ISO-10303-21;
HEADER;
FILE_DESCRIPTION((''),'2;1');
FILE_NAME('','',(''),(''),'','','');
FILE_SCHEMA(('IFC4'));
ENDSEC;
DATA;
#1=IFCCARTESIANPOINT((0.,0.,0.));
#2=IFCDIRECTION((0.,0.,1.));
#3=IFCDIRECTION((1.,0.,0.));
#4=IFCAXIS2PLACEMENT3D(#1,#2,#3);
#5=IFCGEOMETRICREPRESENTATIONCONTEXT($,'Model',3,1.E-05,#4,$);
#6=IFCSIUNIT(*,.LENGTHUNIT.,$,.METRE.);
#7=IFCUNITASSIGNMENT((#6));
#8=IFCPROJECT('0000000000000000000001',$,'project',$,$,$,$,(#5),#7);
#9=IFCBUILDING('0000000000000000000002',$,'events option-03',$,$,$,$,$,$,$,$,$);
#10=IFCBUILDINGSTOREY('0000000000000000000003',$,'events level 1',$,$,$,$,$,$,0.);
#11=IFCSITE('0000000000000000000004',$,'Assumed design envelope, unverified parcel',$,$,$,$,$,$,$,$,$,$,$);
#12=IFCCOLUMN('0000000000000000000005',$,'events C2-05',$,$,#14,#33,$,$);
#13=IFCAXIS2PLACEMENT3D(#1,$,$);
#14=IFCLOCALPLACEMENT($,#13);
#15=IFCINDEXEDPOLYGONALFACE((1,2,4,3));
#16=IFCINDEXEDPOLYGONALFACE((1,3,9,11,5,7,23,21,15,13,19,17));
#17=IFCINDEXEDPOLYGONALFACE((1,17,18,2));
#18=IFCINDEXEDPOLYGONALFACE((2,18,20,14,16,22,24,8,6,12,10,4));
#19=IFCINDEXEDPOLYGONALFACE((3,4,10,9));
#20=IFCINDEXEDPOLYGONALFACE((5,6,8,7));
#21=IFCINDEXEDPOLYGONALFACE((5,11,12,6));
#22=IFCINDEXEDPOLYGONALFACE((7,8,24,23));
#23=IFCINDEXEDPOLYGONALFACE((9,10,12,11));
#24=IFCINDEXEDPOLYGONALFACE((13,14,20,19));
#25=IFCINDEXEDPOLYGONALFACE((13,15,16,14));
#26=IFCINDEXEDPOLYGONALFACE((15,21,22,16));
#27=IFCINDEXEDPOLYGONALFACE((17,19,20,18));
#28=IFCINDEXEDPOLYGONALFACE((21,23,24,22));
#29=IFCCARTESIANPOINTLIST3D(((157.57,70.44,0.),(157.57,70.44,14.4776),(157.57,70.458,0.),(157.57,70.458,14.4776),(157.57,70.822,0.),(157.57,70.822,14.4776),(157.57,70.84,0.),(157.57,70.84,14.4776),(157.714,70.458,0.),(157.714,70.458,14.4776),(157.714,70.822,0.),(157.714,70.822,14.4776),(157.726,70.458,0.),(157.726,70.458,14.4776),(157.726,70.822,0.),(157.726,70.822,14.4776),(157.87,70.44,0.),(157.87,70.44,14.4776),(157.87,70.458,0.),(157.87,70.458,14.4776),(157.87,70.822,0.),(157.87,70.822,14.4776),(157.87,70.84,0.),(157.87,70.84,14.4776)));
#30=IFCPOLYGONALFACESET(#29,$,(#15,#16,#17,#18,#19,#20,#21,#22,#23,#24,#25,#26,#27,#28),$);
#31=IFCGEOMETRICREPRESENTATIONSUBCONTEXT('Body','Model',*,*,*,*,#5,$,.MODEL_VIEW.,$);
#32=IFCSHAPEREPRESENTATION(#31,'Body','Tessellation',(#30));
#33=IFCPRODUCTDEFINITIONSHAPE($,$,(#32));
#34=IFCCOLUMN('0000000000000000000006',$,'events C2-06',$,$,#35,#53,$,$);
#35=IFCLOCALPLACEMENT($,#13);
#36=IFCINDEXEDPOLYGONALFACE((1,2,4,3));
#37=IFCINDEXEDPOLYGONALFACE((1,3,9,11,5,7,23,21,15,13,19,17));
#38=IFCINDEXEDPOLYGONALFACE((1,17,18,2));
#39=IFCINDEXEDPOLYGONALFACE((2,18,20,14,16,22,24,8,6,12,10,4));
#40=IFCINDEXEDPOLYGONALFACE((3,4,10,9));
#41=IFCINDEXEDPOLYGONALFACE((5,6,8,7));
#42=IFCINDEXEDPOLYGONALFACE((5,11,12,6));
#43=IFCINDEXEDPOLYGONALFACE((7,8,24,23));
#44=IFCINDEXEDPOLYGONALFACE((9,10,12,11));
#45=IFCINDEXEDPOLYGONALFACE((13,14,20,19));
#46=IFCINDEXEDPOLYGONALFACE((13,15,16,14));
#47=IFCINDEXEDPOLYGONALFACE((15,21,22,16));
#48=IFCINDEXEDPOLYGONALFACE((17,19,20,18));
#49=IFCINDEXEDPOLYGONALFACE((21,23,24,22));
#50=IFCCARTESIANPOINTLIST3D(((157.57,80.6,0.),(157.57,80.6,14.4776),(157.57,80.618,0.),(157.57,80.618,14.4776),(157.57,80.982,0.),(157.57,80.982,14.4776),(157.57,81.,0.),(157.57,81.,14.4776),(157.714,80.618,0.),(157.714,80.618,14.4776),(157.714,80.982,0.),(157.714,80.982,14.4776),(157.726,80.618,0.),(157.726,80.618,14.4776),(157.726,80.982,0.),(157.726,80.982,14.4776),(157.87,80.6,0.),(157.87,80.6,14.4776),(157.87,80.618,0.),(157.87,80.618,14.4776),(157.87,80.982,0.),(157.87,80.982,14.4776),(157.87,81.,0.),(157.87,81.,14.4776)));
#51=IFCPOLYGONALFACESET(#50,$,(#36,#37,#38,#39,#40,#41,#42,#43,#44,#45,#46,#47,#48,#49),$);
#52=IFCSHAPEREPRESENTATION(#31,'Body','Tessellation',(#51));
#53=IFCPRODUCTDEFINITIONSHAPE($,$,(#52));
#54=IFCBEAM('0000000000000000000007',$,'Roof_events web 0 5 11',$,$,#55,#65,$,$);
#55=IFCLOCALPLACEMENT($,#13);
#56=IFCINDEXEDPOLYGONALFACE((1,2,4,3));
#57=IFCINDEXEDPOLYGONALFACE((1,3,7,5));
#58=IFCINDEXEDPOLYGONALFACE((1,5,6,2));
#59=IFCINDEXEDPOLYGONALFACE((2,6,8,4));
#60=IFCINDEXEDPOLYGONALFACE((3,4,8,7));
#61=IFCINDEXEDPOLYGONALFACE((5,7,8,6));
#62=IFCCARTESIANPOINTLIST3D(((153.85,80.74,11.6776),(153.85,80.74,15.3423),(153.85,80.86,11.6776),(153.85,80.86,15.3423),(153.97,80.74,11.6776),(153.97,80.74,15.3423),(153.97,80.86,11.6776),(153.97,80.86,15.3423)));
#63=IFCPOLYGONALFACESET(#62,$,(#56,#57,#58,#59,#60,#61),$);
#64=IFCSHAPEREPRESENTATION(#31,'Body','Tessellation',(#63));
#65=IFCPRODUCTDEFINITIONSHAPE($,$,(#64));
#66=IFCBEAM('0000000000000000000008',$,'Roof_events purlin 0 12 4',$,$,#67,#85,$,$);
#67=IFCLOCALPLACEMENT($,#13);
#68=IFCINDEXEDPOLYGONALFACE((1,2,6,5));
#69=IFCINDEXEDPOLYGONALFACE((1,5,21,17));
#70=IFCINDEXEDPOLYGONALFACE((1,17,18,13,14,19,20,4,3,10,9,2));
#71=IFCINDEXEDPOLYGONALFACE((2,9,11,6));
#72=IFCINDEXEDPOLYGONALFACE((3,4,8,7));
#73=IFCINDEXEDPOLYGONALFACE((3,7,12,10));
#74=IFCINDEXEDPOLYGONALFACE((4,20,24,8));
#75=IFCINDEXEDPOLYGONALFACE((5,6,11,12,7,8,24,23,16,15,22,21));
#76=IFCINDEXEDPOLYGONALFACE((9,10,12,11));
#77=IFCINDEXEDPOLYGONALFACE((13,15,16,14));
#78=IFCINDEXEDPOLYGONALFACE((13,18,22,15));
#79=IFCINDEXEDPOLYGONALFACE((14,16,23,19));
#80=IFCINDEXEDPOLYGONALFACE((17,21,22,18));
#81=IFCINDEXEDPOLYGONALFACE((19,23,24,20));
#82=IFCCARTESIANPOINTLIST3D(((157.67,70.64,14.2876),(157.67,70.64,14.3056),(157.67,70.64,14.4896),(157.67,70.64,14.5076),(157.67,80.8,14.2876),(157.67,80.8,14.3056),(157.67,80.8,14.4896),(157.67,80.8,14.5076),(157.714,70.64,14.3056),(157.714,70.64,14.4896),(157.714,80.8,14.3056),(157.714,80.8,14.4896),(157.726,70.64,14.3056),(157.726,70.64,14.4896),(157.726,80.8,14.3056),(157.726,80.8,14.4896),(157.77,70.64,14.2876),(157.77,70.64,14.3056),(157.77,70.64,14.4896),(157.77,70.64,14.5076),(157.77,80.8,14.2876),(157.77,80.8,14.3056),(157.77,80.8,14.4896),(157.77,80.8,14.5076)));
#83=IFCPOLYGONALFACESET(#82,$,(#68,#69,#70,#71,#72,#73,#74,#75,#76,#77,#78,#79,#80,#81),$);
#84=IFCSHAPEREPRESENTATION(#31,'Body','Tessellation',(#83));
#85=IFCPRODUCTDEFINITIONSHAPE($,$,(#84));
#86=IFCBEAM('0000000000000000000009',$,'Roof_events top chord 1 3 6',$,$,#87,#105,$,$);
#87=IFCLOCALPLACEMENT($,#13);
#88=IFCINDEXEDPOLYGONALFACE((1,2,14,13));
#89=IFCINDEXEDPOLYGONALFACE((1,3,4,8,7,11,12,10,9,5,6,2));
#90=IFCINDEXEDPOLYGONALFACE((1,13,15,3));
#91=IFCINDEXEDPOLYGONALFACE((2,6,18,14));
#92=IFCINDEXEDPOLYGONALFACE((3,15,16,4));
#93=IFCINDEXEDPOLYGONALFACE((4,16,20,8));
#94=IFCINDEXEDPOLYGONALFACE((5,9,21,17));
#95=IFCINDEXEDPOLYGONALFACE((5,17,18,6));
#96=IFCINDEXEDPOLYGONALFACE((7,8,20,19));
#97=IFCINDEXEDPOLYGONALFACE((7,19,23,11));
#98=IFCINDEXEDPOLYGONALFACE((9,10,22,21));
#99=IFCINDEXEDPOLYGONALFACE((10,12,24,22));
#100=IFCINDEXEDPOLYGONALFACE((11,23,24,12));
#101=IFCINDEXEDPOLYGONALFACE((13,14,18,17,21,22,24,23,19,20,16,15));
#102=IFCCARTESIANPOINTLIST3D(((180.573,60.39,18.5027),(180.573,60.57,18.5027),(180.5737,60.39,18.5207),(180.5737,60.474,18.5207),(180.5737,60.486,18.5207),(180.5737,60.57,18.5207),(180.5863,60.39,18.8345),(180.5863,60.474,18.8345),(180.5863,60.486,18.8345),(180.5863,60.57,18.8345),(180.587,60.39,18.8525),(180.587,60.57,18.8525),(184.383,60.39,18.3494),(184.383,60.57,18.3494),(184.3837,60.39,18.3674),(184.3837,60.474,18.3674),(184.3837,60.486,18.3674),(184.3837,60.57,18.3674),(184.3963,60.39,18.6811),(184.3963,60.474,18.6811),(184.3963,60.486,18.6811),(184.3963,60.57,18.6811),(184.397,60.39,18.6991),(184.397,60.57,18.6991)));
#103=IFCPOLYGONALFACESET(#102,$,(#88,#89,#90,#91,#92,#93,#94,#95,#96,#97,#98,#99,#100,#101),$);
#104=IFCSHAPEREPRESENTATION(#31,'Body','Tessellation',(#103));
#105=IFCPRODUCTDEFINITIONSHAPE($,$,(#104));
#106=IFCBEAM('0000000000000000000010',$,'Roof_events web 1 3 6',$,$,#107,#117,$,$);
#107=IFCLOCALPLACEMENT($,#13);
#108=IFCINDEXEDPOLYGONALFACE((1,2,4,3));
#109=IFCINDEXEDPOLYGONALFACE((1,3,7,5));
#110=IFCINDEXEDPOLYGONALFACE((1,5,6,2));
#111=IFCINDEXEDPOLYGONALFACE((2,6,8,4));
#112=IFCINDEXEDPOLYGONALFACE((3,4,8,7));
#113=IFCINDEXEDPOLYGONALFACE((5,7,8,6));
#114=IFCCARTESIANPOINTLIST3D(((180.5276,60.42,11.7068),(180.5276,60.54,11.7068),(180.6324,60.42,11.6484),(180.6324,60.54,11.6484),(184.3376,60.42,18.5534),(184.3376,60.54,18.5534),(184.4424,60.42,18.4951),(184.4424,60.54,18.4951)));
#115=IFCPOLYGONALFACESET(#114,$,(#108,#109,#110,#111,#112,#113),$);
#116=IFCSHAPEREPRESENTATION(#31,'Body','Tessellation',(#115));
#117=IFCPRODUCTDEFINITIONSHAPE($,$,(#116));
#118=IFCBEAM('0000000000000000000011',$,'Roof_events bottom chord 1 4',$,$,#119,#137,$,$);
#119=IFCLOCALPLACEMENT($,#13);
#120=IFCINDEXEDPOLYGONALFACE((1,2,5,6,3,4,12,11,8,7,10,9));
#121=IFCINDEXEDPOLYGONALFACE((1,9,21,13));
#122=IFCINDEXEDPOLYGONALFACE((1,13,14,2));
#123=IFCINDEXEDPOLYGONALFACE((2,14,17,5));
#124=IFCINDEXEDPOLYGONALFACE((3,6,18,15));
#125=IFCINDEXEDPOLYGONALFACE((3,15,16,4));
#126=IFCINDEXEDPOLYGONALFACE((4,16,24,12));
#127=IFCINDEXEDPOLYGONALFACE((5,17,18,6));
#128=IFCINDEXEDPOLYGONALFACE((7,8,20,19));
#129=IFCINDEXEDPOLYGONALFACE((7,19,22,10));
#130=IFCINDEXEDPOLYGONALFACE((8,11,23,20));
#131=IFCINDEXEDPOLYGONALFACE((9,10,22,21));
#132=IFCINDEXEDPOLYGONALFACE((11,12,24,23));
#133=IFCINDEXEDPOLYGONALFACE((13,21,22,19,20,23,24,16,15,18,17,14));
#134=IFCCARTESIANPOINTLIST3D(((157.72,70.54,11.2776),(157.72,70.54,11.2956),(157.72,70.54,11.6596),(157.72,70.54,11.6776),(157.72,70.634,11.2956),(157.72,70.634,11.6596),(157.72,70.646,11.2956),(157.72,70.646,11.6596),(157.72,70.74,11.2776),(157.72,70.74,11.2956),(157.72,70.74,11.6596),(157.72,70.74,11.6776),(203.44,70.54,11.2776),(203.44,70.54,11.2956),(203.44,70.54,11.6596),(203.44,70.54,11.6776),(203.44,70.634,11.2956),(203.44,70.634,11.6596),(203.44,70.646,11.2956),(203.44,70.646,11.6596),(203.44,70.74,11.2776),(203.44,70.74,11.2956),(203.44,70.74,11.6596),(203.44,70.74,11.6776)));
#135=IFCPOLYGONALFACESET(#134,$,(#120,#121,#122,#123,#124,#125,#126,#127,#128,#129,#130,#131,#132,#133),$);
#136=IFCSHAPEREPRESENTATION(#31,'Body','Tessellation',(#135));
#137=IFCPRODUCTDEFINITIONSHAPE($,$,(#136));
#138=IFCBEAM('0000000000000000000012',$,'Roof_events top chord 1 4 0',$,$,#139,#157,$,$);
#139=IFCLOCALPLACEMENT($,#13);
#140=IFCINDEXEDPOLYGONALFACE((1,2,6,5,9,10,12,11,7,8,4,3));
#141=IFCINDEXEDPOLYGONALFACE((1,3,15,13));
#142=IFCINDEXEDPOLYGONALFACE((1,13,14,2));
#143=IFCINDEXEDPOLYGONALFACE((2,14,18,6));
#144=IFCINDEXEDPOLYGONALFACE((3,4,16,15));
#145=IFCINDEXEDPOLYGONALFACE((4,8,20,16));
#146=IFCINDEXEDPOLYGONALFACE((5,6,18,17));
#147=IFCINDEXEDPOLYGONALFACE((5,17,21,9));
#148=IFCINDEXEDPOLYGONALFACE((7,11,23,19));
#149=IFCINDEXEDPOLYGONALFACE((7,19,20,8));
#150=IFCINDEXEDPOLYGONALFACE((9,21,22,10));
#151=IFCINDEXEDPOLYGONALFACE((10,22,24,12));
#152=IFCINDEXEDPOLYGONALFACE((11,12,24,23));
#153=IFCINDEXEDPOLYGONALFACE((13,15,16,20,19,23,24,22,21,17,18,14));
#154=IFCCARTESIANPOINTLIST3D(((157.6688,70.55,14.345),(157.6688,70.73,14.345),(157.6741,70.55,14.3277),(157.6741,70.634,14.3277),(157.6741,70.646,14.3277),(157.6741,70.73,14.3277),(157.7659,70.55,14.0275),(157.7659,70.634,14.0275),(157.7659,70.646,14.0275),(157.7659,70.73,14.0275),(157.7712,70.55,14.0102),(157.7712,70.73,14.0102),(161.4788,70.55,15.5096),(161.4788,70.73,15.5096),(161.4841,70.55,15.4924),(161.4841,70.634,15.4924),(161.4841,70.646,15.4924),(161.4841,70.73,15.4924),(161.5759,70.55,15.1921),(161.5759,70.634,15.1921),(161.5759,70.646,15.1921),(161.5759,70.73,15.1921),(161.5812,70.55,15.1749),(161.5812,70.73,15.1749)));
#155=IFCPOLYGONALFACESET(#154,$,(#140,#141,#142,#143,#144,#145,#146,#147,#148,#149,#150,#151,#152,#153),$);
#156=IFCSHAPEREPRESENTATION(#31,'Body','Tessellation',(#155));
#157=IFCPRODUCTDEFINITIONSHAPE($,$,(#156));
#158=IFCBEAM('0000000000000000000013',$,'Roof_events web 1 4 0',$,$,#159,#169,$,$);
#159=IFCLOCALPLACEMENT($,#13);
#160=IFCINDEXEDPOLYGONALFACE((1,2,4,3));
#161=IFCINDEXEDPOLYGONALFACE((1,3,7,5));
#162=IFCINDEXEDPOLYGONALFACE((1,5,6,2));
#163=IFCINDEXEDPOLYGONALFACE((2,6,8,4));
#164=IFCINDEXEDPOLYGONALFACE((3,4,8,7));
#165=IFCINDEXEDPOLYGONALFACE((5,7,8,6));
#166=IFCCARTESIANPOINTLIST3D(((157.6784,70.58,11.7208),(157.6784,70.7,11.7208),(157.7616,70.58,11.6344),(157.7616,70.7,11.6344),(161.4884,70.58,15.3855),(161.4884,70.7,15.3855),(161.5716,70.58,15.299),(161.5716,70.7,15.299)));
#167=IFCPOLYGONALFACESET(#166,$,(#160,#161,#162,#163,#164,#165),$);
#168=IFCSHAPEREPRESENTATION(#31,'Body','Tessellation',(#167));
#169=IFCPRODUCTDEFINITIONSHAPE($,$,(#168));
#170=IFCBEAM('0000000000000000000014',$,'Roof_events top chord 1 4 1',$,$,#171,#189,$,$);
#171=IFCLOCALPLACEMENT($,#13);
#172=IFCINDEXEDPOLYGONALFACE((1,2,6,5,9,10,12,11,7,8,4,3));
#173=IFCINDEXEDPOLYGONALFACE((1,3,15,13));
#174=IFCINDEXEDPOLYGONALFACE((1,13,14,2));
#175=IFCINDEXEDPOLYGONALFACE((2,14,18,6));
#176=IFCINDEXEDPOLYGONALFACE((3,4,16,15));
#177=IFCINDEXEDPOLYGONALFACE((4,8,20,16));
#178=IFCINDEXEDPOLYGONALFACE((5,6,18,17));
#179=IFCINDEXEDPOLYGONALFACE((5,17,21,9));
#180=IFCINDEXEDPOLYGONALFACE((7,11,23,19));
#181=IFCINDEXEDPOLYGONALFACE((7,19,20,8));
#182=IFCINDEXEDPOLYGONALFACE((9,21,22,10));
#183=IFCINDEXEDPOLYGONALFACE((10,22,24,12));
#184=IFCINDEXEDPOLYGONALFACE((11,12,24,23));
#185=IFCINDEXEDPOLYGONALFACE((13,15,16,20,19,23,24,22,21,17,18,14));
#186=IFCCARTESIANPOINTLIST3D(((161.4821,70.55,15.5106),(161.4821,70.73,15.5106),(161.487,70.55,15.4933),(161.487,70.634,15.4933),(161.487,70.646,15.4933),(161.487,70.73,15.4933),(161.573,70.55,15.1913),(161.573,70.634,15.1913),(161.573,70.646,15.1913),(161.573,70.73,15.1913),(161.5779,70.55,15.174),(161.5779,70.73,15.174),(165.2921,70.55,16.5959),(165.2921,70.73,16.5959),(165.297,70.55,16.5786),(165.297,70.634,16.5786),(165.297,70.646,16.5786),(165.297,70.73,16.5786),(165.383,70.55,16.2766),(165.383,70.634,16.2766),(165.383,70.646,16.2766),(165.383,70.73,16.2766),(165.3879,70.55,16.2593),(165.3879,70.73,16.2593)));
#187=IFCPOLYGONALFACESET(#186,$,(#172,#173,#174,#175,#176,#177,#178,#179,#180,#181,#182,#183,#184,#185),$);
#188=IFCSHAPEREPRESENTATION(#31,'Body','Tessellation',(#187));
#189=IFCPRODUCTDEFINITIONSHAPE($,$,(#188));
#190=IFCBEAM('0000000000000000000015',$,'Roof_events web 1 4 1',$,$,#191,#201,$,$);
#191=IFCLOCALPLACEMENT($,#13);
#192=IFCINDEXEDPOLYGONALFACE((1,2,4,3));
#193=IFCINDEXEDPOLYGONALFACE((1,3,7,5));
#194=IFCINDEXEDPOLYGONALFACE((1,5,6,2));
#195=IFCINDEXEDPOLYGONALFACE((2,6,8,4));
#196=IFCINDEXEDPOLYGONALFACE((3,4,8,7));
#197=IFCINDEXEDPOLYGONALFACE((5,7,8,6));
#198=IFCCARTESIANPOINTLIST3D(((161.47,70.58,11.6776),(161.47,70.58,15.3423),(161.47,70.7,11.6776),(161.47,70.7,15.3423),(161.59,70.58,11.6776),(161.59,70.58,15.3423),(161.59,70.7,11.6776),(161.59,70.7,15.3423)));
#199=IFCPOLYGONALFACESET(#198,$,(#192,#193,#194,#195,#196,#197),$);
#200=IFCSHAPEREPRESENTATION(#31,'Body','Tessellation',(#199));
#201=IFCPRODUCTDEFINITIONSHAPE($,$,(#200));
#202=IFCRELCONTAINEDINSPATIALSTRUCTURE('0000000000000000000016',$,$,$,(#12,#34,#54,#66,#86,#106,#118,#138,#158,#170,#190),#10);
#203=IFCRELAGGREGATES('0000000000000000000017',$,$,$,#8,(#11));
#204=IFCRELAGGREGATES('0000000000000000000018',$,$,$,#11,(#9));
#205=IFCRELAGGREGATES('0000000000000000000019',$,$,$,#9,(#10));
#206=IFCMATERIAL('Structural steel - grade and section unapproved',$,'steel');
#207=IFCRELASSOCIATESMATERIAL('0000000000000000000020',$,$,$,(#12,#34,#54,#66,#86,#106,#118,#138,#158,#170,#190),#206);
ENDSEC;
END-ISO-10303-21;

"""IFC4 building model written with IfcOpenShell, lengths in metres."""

from ifc_helpers import new_model, si_unit, frame, origin_with_axes, place, context, subcontext, project, spatial, rectangle, i_section, extrude, material, element, save


model = new_model("IFC4")

# Units and contexts
model_context = context("Model", 3, precision=1e-05, world=origin_with_axes())
body_context = subcontext(model_context, "Body", "Model", "MODEL_VIEW")
ifc_project = project(units=[si_unit("LENGTHUNIT", "METRE")], contexts=[model_context])

# Site, building, storey
site = spatial("IfcSite", under=ifc_project, Name="Assumed design envelope, unverified parcel")
building = spatial("IfcBuilding", under=site, Name="events option-03")
storey = spatial("IfcBuildingStorey", under=building, Name="events level 1", Elevation=0.0)

# Columns
ifc_material_1 = material(Name="Structural steel - grade and section unapproved", Category="steel")
for number, where, z_axis, x_axis, name in (
    (1, (157.72, 70.64, 0.0), (0.0, 0.0, 1.0), (-1.0, 0.0, 0.0), "events C2-05"),
    (2, (157.72, 80.8, 0.0), (0.0, 0.0, 1.0), (-1.0, 0.0, 0.0), "events C2-06"),
):
    element("IfcColumn", number, at=place(None, frame(where, z_axis=z_axis, x_axis=x_axis)), inside=storey, material=ifc_material_1, Name=name, context=body_context, shape_type="SweptSolid", body=[
        extrude(i_section(OverallWidth=0.3, OverallDepth=0.4, WebThickness=0.012, FlangeThickness=0.018, FilletRadius=0.0), origin_with_axes(), (0.0, 0.0, 1.0), 14.4776),
    ])

# Beams
beam_1_placement = place(None, frame((153.91, 80.8, 11.6776), z_axis=(0.0, 0.0, 1.0), x_axis=(-1.0, 0.0, 0.0)))
element("IfcBeam", 3, at=beam_1_placement, inside=storey, material=ifc_material_1, Name="Roof_events web 0 5 11", context=body_context, shape_type="SweptSolid", body=[
    extrude(rectangle(XDim=0.12, YDim=0.12), origin_with_axes(), (0.0, 0.0, 1.0), 3.6647),
])
beam_2_placement = place(None, frame((157.72, 70.64, 14.3976), z_axis=(0.0, 1.0, 0.0), x_axis=(-1.0, 0.0, 0.0)))
element("IfcBeam", 4, at=beam_2_placement, inside=storey, material=ifc_material_1, Name="Roof_events purlin 0 12 4", context=body_context, shape_type="SweptSolid", body=[
    extrude(i_section(OverallWidth=0.1, OverallDepth=0.22, WebThickness=0.012, FlangeThickness=0.018, FilletRadius=0.0), origin_with_axes(), (0.0, 0.0, 1.0), 10.16),
])
beam_3_placement = place(None, frame((180.58, 60.48, 18.6776), z_axis=(0.999191, 0.0, -0.040212), x_axis=(0.0, 1.0, 0.0)))
element("IfcBeam", 5, at=beam_3_placement, inside=storey, material=ifc_material_1, Name="Roof_events top chord 1 3 6", context=body_context, shape_type="SweptSolid", body=[
    extrude(i_section(OverallWidth=0.18, OverallDepth=0.35, WebThickness=0.012, FlangeThickness=0.018, FilletRadius=0.0), origin_with_axes(), (0.0, 0.0, 1.0), 3.8131),
])
beam_4_placement = place(None, frame((180.58, 60.48, 11.6776), z_axis=(0.486257, 0.0, 0.873816), x_axis=(0.0, 1.0, 0.0)))
element("IfcBeam", 6, at=beam_4_placement, inside=storey, material=ifc_material_1, Name="Roof_events web 1 3 6", context=body_context, shape_type="SweptSolid", body=[
    extrude(rectangle(XDim=0.12, YDim=0.12), origin_with_axes(), (0.0, 0.0, 1.0), 7.8354),
])
beam_5_placement = place(None, frame((157.72, 70.64, 11.4776), z_axis=(1.0, 0.0, 0.0), x_axis=(0.0, 1.0, 0.0)))
element("IfcBeam", 7, at=beam_5_placement, inside=storey, material=ifc_material_1, Name="Roof_events bottom chord 1 4", context=body_context, shape_type="SweptSolid", body=[
    extrude(i_section(OverallWidth=0.2, OverallDepth=0.4, WebThickness=0.012, FlangeThickness=0.018, FilletRadius=0.0), origin_with_axes(), (0.0, 0.0, 1.0), 45.72),
])
beam_6_placement = place(None, frame((157.72, 70.64, 14.1776), z_axis=(0.956315, 0.0, 0.292338), x_axis=(0.0, 1.0, 0.0)))
element("IfcBeam", 8, at=beam_6_placement, inside=storey, material=ifc_material_1, Name="Roof_events top chord 1 4 0", context=body_context, shape_type="SweptSolid", body=[
    extrude(i_section(OverallWidth=0.18, OverallDepth=0.35, WebThickness=0.012, FlangeThickness=0.018, FilletRadius=0.0), origin_with_axes(), (0.0, 0.0, 1.0), 3.984),
])
beam_7_placement = place(None, frame((157.72, 70.64, 11.6776), z_axis=(0.720717, 0.0, 0.693229), x_axis=(0.0, 1.0, 0.0)))
element("IfcBeam", 9, at=beam_7_placement, inside=storey, material=ifc_material_1, Name="Roof_events web 1 4 0", context=body_context, shape_type="SweptSolid", body=[
    extrude(rectangle(XDim=0.12, YDim=0.12), origin_with_axes(), (0.0, 0.0, 1.0), 5.2864),
])
beam_8_placement = place(None, frame((161.53, 70.64, 15.3423), z_axis=(0.961741, 0.0, 0.273961), x_axis=(0.0, 1.0, 0.0)))
element("IfcBeam", 10, at=beam_8_placement, inside=storey, material=ifc_material_1, Name="Roof_events top chord 1 4 1", context=body_context, shape_type="SweptSolid", body=[
    extrude(i_section(OverallWidth=0.18, OverallDepth=0.35, WebThickness=0.012, FlangeThickness=0.018, FilletRadius=0.0), origin_with_axes(), (0.0, 0.0, 1.0), 3.9616),
])
beam_9_placement = place(None, frame((161.53, 70.64, 11.6776), z_axis=(0.0, 0.0, 1.0), x_axis=(-1.0, 0.0, 0.0)))
element("IfcBeam", 11, at=beam_9_placement, inside=storey, material=ifc_material_1, Name="Roof_events web 1 4 1", context=body_context, shape_type="SweptSolid", body=[
    extrude(rectangle(XDim=0.12, YDim=0.12), origin_with_axes(), (0.0, 0.0, 1.0), 3.6647),
])

save(model, "model.ifc")
